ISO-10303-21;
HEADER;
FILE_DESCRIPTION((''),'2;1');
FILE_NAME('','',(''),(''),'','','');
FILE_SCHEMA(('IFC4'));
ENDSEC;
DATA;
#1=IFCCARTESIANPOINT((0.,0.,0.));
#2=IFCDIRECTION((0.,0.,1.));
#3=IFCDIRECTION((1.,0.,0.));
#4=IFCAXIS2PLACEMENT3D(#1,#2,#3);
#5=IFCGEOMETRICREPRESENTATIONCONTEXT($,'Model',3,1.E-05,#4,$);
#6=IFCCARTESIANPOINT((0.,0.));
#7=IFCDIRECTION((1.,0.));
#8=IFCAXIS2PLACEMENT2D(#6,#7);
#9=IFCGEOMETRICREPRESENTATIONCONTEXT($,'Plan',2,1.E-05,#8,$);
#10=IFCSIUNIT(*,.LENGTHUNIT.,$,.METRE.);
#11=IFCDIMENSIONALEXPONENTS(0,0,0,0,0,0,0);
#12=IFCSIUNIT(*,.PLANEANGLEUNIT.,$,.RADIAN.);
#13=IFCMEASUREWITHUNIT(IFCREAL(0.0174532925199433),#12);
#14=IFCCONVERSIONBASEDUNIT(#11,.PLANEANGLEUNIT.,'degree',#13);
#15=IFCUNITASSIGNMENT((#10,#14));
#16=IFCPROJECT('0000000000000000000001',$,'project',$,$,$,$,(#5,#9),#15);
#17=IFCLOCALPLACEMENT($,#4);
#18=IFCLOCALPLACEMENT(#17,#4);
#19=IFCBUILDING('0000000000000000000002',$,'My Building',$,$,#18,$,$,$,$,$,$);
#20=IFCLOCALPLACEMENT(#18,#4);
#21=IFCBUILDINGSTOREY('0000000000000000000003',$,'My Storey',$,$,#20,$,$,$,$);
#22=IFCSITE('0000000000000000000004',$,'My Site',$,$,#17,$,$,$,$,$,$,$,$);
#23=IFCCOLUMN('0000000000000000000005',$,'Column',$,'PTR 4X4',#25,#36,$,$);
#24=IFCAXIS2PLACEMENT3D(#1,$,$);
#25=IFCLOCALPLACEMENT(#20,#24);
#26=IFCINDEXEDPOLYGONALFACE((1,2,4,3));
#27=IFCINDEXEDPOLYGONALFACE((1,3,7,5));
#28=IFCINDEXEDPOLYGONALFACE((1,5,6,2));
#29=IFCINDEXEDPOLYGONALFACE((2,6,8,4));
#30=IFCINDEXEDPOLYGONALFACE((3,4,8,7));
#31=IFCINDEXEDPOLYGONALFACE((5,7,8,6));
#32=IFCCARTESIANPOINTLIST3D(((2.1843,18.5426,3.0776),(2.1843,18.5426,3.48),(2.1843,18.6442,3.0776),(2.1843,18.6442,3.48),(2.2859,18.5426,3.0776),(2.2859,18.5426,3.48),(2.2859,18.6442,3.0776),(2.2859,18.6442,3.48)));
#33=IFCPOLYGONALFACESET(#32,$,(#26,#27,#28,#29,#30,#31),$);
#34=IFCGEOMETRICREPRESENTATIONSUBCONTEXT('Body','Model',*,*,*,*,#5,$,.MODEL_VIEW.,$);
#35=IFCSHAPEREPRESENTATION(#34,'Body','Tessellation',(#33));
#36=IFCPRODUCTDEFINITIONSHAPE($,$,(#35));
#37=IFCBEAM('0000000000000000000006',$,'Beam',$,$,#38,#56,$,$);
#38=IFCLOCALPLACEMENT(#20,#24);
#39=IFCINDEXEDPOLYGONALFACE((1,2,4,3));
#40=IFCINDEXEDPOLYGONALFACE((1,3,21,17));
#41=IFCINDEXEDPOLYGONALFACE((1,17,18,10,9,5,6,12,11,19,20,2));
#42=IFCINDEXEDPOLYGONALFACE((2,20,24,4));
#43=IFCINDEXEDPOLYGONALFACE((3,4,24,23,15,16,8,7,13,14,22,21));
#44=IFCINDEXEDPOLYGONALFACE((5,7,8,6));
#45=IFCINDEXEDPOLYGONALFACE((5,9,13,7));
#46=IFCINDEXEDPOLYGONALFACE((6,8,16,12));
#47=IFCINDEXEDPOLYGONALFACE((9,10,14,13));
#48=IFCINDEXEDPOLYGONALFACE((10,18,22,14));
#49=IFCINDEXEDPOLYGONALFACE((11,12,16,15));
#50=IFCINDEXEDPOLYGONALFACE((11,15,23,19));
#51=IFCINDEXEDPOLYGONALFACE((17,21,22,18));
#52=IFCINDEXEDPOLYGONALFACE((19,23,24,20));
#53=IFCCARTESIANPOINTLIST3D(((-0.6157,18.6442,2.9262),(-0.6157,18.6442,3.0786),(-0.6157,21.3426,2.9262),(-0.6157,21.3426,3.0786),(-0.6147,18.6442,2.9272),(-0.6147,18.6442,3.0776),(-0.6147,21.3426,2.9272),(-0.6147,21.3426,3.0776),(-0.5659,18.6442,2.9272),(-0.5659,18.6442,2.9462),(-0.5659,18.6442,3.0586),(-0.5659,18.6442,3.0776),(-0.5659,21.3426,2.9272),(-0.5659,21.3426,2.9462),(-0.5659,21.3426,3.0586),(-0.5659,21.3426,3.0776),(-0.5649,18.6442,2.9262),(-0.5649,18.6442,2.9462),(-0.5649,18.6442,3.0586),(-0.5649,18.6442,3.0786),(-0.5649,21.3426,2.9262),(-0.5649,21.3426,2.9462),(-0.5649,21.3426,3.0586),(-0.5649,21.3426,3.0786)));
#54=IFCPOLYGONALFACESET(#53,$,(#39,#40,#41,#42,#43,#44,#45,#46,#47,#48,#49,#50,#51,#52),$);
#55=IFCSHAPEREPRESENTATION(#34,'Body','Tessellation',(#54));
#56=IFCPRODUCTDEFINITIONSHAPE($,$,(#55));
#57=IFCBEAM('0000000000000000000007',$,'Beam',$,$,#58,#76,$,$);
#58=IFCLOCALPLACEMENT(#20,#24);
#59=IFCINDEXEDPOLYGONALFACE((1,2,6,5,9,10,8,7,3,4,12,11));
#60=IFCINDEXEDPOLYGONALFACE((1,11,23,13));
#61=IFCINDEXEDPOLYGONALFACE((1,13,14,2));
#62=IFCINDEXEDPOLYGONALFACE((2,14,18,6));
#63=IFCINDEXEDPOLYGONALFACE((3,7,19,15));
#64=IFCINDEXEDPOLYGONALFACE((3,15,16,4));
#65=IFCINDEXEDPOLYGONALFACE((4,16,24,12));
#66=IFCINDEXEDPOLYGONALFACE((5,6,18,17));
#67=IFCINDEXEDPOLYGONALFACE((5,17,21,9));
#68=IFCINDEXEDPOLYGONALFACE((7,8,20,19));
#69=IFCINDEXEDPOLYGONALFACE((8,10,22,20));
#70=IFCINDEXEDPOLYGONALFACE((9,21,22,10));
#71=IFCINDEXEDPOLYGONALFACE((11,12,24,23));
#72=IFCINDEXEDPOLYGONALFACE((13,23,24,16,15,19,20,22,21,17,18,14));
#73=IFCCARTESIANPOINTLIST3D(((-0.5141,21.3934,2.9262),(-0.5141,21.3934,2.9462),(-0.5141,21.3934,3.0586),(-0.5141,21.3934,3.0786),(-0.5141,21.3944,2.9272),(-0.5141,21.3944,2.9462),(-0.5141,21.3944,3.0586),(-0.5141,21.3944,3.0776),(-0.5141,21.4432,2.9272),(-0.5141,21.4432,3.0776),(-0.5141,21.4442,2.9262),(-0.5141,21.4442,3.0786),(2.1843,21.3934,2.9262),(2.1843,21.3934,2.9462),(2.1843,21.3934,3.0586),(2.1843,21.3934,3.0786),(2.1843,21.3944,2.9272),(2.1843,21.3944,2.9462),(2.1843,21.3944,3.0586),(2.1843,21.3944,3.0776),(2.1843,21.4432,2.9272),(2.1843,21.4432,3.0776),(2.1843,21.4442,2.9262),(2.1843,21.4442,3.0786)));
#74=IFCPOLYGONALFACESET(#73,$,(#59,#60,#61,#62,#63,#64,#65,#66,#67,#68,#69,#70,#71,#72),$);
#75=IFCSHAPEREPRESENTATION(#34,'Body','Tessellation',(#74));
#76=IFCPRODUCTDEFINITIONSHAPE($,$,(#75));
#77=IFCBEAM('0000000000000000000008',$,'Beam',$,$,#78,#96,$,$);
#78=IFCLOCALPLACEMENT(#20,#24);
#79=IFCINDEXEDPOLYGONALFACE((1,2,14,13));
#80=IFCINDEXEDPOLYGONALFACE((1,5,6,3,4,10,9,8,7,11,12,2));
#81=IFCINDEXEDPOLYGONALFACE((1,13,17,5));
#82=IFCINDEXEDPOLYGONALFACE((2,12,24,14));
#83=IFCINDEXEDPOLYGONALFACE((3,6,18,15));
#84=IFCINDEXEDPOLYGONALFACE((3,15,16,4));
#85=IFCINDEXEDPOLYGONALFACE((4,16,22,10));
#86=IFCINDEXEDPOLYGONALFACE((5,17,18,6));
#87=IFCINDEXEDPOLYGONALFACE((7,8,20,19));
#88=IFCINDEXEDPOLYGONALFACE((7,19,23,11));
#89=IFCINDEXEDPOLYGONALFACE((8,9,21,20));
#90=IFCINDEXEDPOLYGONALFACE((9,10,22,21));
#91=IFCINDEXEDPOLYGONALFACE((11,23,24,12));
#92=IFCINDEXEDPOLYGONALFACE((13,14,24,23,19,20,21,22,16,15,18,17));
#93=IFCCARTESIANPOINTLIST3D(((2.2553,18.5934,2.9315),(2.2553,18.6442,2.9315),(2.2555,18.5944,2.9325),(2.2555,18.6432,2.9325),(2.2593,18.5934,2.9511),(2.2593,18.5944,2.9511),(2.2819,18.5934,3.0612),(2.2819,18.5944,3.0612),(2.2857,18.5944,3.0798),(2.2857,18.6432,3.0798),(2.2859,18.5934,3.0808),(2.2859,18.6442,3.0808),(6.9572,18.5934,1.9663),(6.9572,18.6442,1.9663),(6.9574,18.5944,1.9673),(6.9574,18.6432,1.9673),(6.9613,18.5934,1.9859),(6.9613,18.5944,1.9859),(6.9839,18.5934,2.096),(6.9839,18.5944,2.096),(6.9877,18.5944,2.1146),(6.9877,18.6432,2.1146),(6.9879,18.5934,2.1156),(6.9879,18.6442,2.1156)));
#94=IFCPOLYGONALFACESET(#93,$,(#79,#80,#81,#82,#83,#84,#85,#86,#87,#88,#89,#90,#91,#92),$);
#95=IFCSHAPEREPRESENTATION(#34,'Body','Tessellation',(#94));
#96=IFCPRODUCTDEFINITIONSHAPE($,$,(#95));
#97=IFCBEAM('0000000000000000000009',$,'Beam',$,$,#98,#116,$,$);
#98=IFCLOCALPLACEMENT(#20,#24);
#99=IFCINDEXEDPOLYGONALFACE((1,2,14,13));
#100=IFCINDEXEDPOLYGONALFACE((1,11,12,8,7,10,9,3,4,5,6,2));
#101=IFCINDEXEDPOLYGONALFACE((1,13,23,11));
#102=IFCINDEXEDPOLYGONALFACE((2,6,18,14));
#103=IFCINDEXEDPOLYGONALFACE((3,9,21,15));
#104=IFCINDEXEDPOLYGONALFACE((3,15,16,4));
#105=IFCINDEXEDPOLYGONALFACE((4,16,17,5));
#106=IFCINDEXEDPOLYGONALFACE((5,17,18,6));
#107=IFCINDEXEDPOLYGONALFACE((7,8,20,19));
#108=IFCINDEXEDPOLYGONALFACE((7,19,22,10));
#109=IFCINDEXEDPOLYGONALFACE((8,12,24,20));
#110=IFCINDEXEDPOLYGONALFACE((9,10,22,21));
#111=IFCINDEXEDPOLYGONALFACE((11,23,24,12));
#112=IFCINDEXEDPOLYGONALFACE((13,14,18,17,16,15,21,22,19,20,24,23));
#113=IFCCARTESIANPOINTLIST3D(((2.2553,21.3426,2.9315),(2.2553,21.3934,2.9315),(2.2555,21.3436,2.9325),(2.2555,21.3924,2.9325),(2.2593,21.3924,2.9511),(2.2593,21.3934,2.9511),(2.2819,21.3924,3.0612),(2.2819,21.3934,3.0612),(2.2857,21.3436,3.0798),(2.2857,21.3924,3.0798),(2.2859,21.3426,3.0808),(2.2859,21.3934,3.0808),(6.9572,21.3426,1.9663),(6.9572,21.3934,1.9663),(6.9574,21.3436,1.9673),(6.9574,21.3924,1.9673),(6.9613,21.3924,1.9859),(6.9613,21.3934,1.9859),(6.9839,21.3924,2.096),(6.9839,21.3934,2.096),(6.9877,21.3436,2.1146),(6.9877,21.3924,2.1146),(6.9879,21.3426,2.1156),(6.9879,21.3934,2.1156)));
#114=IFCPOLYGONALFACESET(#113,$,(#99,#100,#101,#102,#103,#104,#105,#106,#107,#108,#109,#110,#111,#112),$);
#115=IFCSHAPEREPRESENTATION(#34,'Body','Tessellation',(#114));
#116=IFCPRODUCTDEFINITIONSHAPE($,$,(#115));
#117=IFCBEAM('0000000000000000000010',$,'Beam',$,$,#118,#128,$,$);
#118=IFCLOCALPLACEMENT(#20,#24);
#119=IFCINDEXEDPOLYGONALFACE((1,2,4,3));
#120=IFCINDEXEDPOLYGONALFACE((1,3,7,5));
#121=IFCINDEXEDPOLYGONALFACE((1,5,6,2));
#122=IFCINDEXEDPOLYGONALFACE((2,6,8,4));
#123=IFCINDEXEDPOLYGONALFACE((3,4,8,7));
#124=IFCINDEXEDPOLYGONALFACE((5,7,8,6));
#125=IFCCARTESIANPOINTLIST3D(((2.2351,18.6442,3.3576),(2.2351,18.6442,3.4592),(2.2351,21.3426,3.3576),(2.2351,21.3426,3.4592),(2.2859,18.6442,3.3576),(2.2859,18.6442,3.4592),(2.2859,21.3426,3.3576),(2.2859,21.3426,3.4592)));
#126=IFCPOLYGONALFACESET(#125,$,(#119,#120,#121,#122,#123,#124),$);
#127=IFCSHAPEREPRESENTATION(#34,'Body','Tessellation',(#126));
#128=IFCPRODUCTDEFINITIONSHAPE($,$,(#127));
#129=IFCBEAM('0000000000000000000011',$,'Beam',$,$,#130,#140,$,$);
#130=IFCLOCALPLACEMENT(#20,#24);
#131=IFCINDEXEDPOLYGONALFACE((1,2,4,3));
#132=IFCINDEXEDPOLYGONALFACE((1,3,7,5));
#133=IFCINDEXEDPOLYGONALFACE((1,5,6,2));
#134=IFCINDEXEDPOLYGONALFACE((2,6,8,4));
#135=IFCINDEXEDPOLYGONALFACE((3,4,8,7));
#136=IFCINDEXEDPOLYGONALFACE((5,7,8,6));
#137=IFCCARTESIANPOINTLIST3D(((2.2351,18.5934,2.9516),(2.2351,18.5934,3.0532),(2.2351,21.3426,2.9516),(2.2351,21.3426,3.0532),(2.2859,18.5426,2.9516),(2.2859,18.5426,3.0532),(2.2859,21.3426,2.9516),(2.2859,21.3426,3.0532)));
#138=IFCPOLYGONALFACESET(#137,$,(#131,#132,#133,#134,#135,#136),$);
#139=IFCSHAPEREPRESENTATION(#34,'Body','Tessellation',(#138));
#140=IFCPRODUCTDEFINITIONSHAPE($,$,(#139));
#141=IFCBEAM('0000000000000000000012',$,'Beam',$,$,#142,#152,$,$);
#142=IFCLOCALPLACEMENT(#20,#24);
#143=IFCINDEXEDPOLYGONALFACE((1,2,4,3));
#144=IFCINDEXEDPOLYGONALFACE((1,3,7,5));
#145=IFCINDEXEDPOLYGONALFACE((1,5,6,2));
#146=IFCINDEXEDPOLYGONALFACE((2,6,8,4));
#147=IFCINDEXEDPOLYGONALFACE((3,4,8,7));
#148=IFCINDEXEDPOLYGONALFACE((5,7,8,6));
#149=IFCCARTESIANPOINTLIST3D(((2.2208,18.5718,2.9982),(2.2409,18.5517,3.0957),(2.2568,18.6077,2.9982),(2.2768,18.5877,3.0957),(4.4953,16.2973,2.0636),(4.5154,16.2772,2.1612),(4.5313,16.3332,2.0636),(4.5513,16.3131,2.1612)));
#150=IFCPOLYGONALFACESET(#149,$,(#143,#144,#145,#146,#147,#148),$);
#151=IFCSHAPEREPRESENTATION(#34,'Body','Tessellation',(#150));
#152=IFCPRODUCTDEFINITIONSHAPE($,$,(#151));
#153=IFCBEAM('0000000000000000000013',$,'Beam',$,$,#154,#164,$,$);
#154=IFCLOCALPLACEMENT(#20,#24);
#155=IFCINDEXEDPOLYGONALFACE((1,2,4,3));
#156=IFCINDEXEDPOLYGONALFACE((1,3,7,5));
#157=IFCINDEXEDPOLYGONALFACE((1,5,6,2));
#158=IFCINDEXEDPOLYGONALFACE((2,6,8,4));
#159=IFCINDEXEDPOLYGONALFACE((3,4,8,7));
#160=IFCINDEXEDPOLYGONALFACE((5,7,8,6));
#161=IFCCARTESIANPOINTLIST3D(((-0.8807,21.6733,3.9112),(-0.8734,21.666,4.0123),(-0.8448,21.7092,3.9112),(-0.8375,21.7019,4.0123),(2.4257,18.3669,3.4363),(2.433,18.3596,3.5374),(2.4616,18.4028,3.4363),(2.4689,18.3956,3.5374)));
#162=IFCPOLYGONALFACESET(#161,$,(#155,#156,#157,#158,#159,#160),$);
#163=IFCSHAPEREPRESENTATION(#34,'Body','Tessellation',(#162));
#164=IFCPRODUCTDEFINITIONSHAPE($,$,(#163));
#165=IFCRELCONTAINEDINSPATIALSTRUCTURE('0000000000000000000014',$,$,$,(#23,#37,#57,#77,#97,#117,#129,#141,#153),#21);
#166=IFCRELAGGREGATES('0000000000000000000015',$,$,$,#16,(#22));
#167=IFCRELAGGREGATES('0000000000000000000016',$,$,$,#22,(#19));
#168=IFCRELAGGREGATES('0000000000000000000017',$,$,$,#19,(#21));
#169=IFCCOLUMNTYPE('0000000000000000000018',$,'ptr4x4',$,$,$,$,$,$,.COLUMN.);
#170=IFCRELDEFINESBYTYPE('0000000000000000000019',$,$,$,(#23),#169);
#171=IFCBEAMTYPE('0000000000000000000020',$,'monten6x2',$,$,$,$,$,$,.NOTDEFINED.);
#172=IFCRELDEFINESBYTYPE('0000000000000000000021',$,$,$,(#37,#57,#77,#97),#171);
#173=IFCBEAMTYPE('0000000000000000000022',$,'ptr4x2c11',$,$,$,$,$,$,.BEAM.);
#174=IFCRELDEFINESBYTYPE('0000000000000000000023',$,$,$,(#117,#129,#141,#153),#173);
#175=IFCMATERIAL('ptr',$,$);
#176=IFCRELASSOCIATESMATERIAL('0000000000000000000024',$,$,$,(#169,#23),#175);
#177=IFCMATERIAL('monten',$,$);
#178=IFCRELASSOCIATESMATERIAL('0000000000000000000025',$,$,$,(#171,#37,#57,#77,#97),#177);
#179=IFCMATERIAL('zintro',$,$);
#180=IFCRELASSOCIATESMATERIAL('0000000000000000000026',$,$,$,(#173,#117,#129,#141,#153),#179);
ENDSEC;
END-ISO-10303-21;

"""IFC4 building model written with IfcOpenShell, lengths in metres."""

from ifc_helpers import new_model, entity, si_unit, converted_unit, frame, origin_with_axes, origin_2d_with_axis, place, context, subcontext, project, spatial, rectangle, c_section, extrude, clip, halfspace, material, material_profile, profile_set, profile_usage, type_object, element, save


model = new_model("IFC4")

# Units and contexts
model_context = context("Model", 3, precision=1e-05, world=origin_with_axes())
plan_context = context("Plan", 2, precision=1e-05, world=origin_2d_with_axis())
body_context = subcontext(model_context, "Body", "Model", "MODEL_VIEW")
ifc_project = project(units=[si_unit("LENGTHUNIT", "METRE"), converted_unit("PLANEANGLEUNIT", "degree", entity("IfcReal", 0.0174532925199433), si_unit("PLANEANGLEUNIT", "RADIAN"), dimensions=[0, 0, 0, 0, 0, 0, 0])], contexts=[model_context, plan_context])

# Site, building, storey
site_placement = place(None, origin_with_axes())
site = spatial("IfcSite", under=ifc_project, at=site_placement, Name="My Site")
building_placement = place(site_placement, origin_with_axes())
building = spatial("IfcBuilding", under=site, at=building_placement, Name="My Building")
storey_placement = place(building_placement, origin_with_axes())
storey = spatial("IfcBuildingStorey", under=building, at=storey_placement, Name="My Storey")

# Column
ifc_material_1 = material(Name="ptr")
ifc_material_profile_1 = material_profile(ifc_material_1, rectangle(XDim=0.1016, YDim=0.1016))
ifc_profile_set_1 = profile_set([ifc_material_profile_1])
ifc_profile_usage_1 = profile_usage(ifc_profile_set_1, cardinal=5)
column_type = type_object("IfcColumnType", Name="ptr4x4", PredefinedType="COLUMN", material=ifc_profile_set_1)
column_placement = place(storey_placement, frame((2.2351, 18.5934, 3.0776), z_axis=(0.0, 0.0, 1.0), x_axis=(1.0, 0.0, 0.0)))
element("IfcColumn", 1, at=column_placement, inside=storey, type_object=column_type, material=ifc_profile_usage_1, Name="Column", ObjectType="PTR 4X4", context=body_context, shape_type="SweptSolid", body=[
    extrude(rectangle(XDim=0.1016, YDim=0.1016), origin_with_axes(), (0.0, 0.0, 1.0), 0.4024),
])

# Beams
ifc_material_2 = material(Name="monten")
ifc_material_profile_2 = material_profile(ifc_material_2, c_section(Depth=0.1524, Width=0.0508, WallThickness=0.001, Girth=0.02))
ifc_profile_set_2 = profile_set([ifc_material_profile_2])
ifc_profile_usage_2 = profile_usage(ifc_profile_set_2, cardinal=5)
beam_type_1 = type_object("IfcBeamType", Name="monten6x2", PredefinedType="NOTDEFINED", material=ifc_profile_set_2)
beam_1_placement = place(storey_placement, frame((-0.5903, 21.3426, 3.0024), z_axis=(0.0, -1.0, 0.0), x_axis=(1.0, 0.0, 0.0)))
element("IfcBeam", 2, at=beam_1_placement, inside=storey, type_object=beam_type_1, material=ifc_profile_usage_2, Name="Beam", context=body_context, shape_type="SweptSolid", body=[
    extrude(c_section(Depth=0.1524, Width=0.0508, WallThickness=0.001, Girth=0.02), origin_with_axes(), (0.0, 0.0, 1.0), 2.6984),
])
ifc_profile_usage_3 = profile_usage(ifc_profile_set_2, cardinal=5)
beam_2_placement = place(storey_placement, frame((-0.5141, 21.4188, 3.0024), z_axis=(1.0, 0.0, 0.0), x_axis=(0.0, -1.0, 0.000001)))
element("IfcBeam", 3, at=beam_2_placement, inside=storey, type_object=beam_type_1, material=ifc_profile_usage_3, Name="Beam", context=body_context, shape_type="SweptSolid", body=[
    extrude(c_section(Depth=0.1524, Width=0.0508, WallThickness=0.001, Girth=0.02), origin_with_axes(), (0.0, 0.0, 1.0), 2.6984),
])
ifc_profile_usage_4 = profile_usage(ifc_profile_set_2, cardinal=5)
beam_3_placement = place(storey_placement, frame((2.2706, 18.6188, 3.0061), z_axis=(0.979575, 0.0, -0.201078), x_axis=(0.0, -1.0, 0.000001)))
element("IfcBeam", 4, at=beam_3_placement, inside=storey, type_object=beam_type_1, material=ifc_profile_usage_4, Name="Beam", context=body_context, shape_type="SweptSolid", body=[
    extrude(c_section(Depth=0.1524, Width=0.0508, WallThickness=0.001, Girth=0.02), origin_with_axes(), (0.0, 0.0, 1.0), 4.8),
])
ifc_profile_usage_5 = profile_usage(ifc_profile_set_2, cardinal=5)
beam_4_placement = place(storey_placement, frame((2.2706, 21.368, 3.0061), z_axis=(0.979575, 0.0, -0.201078), x_axis=(0.0, 1.0, 0.0)))
element("IfcBeam", 5, at=beam_4_placement, inside=storey, type_object=beam_type_1, material=ifc_profile_usage_5, Name="Beam", context=body_context, shape_type="SweptSolid", body=[
    extrude(c_section(Depth=0.1524, Width=0.0508, WallThickness=0.001, Girth=0.02), origin_with_axes(), (0.0, 0.0, 1.0), 4.8),
])
ifc_material_3 = material(Name="zintro")
ifc_material_profile_3 = material_profile(ifc_material_3, rectangle(XDim=0.0508, YDim=0.1016))
ifc_profile_set_3 = profile_set([ifc_material_profile_3])
beam_type_2 = type_object("IfcBeamType", Name="ptr4x2c11", PredefinedType="BEAM", material=ifc_profile_set_3)
ifc_profile_usage_6 = profile_usage(ifc_profile_set_3)
beam_5_placement = place(storey_placement, frame((2.2605, 21.3426, 3.4084), z_axis=(0.0, -1.0, 0.0), x_axis=(-1.0, 0.0, 0.0)))
element("IfcBeam", 6, at=beam_5_placement, inside=storey, type_object=beam_type_2, material=ifc_profile_usage_6, Name="Beam", context=body_context, shape_type="SweptSolid", body=[
    extrude(rectangle(XDim=0.0508, YDim=0.1016), origin_with_axes(), (0.0, 0.0, 1.0), 2.6984),
])
ifc_profile_usage_7 = profile_usage(ifc_profile_set_3)
beam_6_placement = place(storey_placement, frame((2.2605, 21.3426, 3.0024), z_axis=(0.0, -1.0, 0.0), x_axis=(-1.0, 0.0, 0.0)))
element("IfcBeam", 7, at=beam_6_placement, inside=storey, type_object=beam_type_2, material=ifc_profile_usage_7, Name="Beam", context=body_context, shape_type="Clipping", body=[
    clip(extrude(rectangle(XDim=0.0508, YDim=0.1016), origin_with_axes(), (0.0, 0.0, 1.0), 2.8), halfspace(frame((-0.0254, 3.0024, 2.8), z_axis=(0.70711, 0.0, 0.707103), x_axis=(0.707103, 0.0, -0.70711)), False)),
])
ifc_profile_usage_8 = profile_usage(ifc_profile_set_3)
beam_7_placement = place(storey_placement, frame((2.2488, 18.5797, 3.0469), z_axis=(0.67903, -0.67903, -0.278991), x_axis=(0.707107, 0.707107, 0.0)))
element("IfcBeam", 8, at=beam_7_placement, inside=storey, type_object=beam_type_2, material=ifc_profile_usage_8, Name="Beam", context=body_context, shape_type="SweptSolid", body=[
    extrude(rectangle(XDim=0.0508, YDim=0.1016), origin_with_axes(), (0.0, 0.0, 1.0), 3.3496),
])
ifc_profile_usage_9 = profile_usage(ifc_profile_set_3)
beam_8_placement = place(storey_placement, frame((-0.8591, 21.6876, 3.9618), z_axis=(0.703487, -0.703487, -0.101056), x_axis=(0.707107, 0.707107, 0.0)))
element("IfcBeam", 9, at=beam_8_placement, inside=storey, type_object=beam_type_2, material=ifc_profile_usage_9, Name="Beam", context=body_context, shape_type="SweptSolid", body=[
    extrude(rectangle(XDim=0.0508, YDim=0.1016), origin_with_axes(), (0.0, 0.0, 1.0), 4.7),
])

save(model, "model.ifc")
